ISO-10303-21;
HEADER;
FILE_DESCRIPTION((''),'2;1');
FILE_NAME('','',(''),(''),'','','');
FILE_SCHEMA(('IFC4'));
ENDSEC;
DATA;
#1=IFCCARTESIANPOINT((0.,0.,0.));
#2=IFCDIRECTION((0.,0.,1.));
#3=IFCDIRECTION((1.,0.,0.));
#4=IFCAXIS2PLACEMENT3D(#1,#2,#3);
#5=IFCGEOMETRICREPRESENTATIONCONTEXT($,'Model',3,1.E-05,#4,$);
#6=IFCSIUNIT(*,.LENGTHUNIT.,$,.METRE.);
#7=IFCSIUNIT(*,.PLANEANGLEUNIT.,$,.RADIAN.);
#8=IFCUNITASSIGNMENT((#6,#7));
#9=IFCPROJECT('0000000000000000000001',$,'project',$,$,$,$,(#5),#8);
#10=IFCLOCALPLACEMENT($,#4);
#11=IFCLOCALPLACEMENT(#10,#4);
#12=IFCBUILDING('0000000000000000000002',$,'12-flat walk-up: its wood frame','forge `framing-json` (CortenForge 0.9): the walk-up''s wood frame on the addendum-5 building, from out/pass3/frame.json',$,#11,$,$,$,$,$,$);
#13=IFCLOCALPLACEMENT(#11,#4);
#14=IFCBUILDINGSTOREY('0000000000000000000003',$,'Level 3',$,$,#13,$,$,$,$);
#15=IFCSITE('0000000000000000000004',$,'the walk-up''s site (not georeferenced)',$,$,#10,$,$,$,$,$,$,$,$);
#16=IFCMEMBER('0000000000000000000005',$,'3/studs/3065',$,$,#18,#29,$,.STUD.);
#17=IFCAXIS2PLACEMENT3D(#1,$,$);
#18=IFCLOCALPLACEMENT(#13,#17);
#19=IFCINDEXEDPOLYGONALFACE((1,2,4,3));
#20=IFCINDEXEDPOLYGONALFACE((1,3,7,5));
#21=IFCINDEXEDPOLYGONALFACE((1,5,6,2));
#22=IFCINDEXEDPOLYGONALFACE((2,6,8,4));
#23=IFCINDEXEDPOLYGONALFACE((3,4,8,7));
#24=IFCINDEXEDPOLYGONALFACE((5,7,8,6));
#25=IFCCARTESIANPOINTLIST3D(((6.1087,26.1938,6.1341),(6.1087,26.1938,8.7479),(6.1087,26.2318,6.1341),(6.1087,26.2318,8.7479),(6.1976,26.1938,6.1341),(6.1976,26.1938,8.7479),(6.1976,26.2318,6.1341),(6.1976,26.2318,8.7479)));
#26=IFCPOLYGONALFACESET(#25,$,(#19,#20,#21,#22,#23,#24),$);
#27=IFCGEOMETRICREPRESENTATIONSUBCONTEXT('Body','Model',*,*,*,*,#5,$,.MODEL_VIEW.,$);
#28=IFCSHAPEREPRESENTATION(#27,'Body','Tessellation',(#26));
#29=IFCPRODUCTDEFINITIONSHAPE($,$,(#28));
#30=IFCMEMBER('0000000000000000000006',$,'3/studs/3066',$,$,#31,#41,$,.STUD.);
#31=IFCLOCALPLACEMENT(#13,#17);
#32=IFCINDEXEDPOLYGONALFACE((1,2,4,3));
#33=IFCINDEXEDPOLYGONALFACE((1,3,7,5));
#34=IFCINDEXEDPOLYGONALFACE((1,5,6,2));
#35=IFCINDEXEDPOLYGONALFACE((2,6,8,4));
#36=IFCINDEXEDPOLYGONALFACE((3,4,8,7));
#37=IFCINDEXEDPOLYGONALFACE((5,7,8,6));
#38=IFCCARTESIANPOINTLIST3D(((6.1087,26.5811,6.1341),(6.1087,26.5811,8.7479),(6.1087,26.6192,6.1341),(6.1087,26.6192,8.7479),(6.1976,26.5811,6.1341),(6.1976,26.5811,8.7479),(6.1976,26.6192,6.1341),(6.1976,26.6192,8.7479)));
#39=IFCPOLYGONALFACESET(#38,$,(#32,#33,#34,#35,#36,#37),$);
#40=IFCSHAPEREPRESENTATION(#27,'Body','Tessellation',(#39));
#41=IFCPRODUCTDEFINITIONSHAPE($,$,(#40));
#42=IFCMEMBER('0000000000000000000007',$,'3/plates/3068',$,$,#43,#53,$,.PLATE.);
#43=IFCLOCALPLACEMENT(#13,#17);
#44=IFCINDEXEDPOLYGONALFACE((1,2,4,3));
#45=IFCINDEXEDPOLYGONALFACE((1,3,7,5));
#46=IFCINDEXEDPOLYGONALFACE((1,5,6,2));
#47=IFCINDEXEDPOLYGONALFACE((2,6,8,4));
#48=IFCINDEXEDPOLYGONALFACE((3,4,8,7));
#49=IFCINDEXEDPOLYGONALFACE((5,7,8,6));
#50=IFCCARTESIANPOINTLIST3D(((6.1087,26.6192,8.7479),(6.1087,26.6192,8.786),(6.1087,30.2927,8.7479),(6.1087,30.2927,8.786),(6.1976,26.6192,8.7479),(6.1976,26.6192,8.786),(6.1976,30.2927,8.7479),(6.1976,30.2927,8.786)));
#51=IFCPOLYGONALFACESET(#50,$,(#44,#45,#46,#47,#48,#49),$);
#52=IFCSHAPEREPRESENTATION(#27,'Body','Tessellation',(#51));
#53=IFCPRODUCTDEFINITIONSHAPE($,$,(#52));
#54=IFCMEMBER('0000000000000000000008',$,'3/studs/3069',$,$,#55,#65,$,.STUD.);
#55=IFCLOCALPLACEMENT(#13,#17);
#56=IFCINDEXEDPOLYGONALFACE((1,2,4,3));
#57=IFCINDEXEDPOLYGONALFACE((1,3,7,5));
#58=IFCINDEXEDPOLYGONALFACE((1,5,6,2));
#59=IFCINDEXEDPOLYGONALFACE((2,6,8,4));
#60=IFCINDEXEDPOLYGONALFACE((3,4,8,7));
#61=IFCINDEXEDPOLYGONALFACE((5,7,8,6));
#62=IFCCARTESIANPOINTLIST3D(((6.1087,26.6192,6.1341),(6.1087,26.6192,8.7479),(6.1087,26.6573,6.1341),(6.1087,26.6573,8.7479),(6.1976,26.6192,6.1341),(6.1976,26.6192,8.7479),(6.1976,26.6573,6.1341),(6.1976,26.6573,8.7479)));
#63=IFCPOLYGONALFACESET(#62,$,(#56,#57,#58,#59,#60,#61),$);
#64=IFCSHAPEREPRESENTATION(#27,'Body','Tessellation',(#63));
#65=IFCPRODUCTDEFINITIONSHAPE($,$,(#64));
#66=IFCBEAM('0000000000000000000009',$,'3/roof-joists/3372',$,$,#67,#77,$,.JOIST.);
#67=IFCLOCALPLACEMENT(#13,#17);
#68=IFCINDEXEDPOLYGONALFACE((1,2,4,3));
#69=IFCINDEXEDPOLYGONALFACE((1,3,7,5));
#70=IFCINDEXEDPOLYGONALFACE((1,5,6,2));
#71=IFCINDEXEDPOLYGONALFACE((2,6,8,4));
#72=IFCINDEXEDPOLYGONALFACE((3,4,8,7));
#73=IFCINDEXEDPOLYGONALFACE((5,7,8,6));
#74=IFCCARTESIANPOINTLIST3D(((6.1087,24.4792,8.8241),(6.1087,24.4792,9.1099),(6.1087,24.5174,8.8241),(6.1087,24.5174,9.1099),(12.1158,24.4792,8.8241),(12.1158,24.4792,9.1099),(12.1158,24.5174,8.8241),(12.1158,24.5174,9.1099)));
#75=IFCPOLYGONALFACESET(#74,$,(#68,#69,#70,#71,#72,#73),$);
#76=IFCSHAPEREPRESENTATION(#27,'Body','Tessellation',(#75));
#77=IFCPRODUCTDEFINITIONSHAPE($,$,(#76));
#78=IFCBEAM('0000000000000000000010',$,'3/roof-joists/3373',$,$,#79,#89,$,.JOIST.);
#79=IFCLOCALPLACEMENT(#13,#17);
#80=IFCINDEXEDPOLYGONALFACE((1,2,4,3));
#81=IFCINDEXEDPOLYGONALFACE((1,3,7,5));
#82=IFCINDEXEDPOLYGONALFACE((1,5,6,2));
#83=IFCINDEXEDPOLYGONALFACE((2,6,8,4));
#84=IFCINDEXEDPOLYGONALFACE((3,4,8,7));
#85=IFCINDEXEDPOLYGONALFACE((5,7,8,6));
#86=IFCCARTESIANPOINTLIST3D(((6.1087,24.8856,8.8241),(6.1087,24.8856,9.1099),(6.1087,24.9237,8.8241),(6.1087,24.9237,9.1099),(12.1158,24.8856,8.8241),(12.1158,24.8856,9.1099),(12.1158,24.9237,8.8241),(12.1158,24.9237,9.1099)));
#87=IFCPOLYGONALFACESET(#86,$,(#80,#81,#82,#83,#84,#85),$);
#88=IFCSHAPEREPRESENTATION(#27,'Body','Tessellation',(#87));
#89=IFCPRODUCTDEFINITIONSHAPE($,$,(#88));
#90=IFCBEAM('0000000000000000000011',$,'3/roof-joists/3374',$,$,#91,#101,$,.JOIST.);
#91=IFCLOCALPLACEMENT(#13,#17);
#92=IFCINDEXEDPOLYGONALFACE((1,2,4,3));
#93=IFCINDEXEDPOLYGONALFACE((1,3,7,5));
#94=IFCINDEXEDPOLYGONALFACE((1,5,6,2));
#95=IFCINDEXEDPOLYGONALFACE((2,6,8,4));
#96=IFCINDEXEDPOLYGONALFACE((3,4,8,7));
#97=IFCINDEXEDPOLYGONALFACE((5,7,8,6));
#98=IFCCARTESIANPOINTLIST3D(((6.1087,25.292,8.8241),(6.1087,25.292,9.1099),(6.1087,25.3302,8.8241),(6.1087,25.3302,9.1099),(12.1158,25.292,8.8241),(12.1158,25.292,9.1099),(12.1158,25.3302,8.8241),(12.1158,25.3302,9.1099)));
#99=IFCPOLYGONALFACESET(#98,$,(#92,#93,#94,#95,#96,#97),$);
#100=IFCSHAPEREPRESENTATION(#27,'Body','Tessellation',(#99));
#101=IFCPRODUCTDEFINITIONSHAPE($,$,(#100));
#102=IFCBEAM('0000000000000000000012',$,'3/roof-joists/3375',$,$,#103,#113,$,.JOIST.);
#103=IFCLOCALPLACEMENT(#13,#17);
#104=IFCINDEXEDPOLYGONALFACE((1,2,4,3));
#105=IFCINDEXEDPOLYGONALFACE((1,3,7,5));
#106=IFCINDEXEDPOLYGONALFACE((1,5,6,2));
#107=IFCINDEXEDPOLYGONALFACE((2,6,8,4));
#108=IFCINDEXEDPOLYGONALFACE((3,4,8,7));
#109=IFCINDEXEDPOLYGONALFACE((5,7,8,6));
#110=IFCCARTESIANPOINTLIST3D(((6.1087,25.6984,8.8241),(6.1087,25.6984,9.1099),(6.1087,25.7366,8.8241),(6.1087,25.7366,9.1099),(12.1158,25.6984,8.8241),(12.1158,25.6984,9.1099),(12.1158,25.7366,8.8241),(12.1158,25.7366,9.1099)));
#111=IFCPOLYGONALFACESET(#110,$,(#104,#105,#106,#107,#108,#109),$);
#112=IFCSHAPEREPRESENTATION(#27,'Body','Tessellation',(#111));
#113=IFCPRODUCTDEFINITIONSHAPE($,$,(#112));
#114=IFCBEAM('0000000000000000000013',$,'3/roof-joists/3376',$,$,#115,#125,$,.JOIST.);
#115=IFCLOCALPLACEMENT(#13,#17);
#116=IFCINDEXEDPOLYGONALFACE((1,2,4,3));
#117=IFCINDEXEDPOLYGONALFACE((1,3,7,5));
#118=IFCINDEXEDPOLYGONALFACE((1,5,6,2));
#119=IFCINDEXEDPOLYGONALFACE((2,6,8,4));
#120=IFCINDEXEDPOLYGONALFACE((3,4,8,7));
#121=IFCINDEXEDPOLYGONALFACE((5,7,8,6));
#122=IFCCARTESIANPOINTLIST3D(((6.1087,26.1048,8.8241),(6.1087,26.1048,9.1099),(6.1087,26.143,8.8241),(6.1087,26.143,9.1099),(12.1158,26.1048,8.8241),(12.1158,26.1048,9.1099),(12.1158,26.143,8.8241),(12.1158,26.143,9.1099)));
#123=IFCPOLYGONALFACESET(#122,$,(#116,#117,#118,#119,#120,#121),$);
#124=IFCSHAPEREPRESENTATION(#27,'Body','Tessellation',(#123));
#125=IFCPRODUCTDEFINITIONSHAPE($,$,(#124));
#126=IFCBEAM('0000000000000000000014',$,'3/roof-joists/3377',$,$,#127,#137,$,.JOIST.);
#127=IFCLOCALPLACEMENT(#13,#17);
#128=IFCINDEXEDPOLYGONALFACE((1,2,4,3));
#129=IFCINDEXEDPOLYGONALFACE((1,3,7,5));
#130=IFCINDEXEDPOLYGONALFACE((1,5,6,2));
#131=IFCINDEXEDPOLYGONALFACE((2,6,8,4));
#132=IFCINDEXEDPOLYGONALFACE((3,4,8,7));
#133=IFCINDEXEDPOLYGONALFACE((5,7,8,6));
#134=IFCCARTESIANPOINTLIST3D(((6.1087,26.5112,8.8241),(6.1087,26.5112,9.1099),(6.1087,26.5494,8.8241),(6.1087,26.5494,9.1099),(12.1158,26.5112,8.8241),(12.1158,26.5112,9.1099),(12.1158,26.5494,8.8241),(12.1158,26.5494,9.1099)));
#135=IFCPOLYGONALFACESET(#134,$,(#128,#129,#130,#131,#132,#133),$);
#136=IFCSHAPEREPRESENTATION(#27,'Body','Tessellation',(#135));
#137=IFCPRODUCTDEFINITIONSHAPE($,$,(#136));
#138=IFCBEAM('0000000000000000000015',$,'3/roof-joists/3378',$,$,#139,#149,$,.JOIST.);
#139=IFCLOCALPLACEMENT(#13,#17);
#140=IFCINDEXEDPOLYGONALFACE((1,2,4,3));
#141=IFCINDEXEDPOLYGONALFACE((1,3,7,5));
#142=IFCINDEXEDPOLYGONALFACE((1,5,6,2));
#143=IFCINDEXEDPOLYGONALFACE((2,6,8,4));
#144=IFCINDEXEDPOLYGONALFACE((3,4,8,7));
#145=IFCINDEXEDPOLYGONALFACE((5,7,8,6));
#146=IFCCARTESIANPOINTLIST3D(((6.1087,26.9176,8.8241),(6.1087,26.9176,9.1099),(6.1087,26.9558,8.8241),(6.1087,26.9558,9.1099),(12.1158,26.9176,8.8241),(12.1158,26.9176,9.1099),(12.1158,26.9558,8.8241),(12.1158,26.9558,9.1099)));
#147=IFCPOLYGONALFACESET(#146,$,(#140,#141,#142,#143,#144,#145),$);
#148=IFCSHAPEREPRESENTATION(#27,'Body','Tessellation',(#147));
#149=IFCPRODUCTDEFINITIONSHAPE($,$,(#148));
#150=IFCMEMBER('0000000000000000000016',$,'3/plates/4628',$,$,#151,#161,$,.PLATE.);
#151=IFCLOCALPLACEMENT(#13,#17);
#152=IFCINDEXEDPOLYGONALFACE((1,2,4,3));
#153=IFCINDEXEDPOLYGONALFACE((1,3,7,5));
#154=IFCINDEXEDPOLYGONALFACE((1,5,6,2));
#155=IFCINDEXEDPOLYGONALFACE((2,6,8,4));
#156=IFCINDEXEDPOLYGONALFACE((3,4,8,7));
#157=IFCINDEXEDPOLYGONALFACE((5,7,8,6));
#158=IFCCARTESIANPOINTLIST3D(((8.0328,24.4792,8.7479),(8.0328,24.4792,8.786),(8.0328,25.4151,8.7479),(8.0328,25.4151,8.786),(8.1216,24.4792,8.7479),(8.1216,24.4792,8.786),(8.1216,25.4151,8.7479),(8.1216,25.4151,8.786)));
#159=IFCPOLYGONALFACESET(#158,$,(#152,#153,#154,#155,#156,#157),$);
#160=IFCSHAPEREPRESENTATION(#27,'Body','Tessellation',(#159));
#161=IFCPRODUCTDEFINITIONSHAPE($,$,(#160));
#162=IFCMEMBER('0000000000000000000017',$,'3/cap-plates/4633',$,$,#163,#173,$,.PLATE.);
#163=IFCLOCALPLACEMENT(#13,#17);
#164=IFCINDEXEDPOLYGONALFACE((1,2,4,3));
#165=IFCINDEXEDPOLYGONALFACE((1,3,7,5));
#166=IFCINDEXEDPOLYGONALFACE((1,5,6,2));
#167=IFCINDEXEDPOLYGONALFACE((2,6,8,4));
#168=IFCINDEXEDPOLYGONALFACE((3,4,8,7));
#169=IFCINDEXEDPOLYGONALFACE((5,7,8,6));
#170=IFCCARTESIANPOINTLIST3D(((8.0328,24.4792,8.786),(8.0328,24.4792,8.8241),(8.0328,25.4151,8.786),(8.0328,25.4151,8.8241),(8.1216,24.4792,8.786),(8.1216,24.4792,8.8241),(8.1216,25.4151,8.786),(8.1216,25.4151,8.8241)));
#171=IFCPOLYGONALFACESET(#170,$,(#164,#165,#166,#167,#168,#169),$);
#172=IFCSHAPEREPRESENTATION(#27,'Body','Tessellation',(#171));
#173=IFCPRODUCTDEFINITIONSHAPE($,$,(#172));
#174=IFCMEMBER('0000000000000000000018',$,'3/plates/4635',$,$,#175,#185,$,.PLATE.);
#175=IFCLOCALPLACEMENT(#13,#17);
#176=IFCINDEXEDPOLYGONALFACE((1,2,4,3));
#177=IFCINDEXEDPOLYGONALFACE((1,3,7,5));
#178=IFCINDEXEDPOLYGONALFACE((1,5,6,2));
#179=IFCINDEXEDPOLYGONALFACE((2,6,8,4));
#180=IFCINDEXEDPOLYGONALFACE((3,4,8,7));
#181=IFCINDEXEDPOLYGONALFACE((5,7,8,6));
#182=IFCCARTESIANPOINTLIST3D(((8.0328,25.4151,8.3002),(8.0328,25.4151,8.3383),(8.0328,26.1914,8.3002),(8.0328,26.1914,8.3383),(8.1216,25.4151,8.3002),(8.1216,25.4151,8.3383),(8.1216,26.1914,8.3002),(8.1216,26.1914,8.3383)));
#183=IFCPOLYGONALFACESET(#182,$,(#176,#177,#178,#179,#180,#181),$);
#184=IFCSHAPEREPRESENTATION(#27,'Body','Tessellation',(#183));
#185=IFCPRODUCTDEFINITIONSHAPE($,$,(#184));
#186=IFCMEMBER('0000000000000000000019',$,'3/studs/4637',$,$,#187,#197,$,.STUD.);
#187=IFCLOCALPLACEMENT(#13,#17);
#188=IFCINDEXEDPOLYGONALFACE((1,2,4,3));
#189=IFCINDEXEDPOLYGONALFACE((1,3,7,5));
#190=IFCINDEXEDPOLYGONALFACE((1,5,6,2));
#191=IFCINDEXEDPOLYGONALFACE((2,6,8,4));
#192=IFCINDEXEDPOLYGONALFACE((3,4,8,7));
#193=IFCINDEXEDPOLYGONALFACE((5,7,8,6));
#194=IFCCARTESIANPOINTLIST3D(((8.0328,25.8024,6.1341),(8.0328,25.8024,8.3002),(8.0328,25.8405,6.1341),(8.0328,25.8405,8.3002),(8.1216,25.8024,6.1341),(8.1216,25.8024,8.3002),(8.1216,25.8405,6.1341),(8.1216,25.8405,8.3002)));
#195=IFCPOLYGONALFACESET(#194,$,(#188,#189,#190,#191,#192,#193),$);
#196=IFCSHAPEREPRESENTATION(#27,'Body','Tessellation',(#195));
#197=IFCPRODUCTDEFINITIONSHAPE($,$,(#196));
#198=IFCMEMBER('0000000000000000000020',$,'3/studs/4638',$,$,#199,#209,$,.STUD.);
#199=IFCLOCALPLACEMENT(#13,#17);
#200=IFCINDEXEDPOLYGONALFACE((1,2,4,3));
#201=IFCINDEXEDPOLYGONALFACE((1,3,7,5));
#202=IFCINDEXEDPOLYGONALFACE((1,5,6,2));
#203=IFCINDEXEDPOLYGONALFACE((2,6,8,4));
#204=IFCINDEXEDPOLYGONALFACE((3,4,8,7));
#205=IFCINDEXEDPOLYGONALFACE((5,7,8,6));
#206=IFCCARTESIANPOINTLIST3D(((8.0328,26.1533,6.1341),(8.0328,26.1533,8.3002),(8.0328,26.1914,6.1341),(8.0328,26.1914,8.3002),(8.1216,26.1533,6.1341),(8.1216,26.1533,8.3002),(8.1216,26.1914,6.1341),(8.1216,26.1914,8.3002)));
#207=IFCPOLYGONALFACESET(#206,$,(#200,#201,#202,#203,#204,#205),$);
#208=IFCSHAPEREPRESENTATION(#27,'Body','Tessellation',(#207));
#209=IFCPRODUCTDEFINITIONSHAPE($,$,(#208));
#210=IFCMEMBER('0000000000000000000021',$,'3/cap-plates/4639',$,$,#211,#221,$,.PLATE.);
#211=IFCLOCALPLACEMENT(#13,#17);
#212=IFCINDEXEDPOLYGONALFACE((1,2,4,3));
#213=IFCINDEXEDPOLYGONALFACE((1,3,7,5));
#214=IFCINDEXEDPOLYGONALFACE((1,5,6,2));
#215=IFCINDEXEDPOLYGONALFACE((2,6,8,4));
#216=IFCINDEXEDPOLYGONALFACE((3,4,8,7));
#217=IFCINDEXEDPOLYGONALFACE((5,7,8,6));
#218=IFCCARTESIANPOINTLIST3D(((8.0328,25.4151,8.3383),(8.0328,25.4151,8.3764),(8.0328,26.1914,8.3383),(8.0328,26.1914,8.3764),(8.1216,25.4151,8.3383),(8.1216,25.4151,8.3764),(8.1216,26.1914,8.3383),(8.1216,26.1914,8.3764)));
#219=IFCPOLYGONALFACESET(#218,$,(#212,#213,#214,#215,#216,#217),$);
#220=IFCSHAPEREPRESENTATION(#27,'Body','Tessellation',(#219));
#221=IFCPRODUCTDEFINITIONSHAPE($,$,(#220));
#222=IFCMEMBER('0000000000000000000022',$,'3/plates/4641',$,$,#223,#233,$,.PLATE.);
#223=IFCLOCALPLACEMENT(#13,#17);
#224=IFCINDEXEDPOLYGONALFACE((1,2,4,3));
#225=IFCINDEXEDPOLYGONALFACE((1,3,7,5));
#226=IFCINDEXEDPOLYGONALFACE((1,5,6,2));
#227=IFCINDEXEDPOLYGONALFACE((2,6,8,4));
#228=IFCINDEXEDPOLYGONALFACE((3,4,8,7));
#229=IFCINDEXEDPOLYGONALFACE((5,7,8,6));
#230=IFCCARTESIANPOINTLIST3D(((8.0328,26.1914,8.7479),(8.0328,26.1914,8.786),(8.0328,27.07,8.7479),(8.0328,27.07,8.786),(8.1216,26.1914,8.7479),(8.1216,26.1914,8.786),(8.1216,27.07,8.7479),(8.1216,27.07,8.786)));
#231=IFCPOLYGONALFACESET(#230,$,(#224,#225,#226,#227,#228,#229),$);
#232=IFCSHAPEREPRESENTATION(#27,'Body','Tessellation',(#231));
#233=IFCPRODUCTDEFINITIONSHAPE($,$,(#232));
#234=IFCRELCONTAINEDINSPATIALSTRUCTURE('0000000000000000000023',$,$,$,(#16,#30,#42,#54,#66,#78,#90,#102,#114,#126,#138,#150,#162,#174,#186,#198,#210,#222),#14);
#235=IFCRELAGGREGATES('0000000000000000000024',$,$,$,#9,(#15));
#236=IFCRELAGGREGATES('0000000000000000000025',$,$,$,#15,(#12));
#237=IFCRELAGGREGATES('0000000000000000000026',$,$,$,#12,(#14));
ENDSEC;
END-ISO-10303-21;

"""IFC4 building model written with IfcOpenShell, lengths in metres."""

from ifc_helpers import new_model, si_unit, frame, frame_2d, origin, origin_with_axes, place, context, subcontext, project, spatial, rectangle, extrude, element, save


model = new_model("IFC4")

# Units and contexts
model_context = context("Model", 3, precision=1e-05, world=origin_with_axes())
body_context = subcontext(model_context, "Body", "Model", "MODEL_VIEW")
ifc_project = project(units=[si_unit("LENGTHUNIT", "METRE"), si_unit("PLANEANGLEUNIT", "RADIAN")], contexts=[model_context])

# Site, building, storey
site_placement = place(None, origin_with_axes())
site = spatial("IfcSite", under=ifc_project, at=site_placement, Name="the walk-up's site (not georeferenced)")
building_placement = place(site_placement, origin_with_axes())
building = spatial("IfcBuilding", under=site, at=building_placement, Name="12-flat walk-up: its wood frame", Description="forge `framing-json` (CortenForge 0.9): the walk-up's wood frame on the addendum-5 building, from out/pass3/frame.json")
storey_placement = place(building_placement, origin_with_axes())
storey = spatial("IfcBuildingStorey", under=building, at=storey_placement, Name="Level 3")

# Members
for number, where, z_axis, x_axis, name in (
    (1, (6.1087, 26.1938, 6.1341), (0.0, 0.0, 1.0), (1.0, 0.0, 0.0), "3/studs/3065"),
    (2, (6.1087, 26.5811, 6.1341), (0.0, 0.0, 1.0), (1.0, 0.0, 0.0), "3/studs/3066"),
):
    element("IfcMember", number, at=place(storey_placement, frame(where, z_axis=z_axis, x_axis=x_axis)), inside=storey, Name=name, PredefinedType="STUD", context=body_context, shape_type="SweptSolid", body=[
        extrude(rectangle(XDim=0.0889, YDim=0.0381, at=frame_2d((0.0445, 0.0191))), origin(), (0.0, 0.0, 1.0), 2.6138),
    ])
member_1_placement = place(storey_placement, frame((6.1087, 26.6192, 8.7479), z_axis=(0.0, 0.0, 1.0), x_axis=(1.0, 0.0, 0.0)))
element("IfcMember", 3, at=member_1_placement, inside=storey, Name="3/plates/3068", PredefinedType="PLATE", context=body_context, shape_type="SweptSolid", body=[
    extrude(rectangle(XDim=0.0889, YDim=3.6735, at=frame_2d((0.0445, 1.8367))), origin(), (0.0, 0.0, 1.0), 0.0381),
])
member_2_placement = place(storey_placement, frame((6.1087, 26.6192, 6.1341), z_axis=(0.0, 0.0, 1.0), x_axis=(1.0, 0.0, 0.0)))
element("IfcMember", 4, at=member_2_placement, inside=storey, Name="3/studs/3069", PredefinedType="STUD", context=body_context, shape_type="SweptSolid", body=[
    extrude(rectangle(XDim=0.0889, YDim=0.0381, at=frame_2d((0.0445, 0.0191))), origin(), (0.0, 0.0, 1.0), 2.6138),
])

# Beams
for number, where, z_axis, x_axis, name in (
    (5, (6.1087, 24.4793, 8.8241), (0.0, 0.0, 1.0), (1.0, 0.0, 0.0), "3/roof-joists/3372"),
    (6, (6.1087, 24.8856, 8.8241), (0.0, 0.0, 1.0), (1.0, 0.0, 0.0), "3/roof-joists/3373"),
    (7, (6.1087, 25.292, 8.8241), (0.0, 0.0, 1.0), (1.0, 0.0, 0.0), "3/roof-joists/3374"),
    (8, (6.1087, 25.6985, 8.8241), (0.0, 0.0, 1.0), (1.0, 0.0, 0.0), "3/roof-joists/3375"),
    (9, (6.1087, 26.1048, 8.8241), (0.0, 0.0, 1.0), (1.0, 0.0, 0.0), "3/roof-joists/3376"),
    (10, (6.1087, 26.5113, 8.8241), (0.0, 0.0, 1.0), (1.0, 0.0, 0.0), "3/roof-joists/3377"),
    (11, (6.1087, 26.9176, 8.8241), (0.0, 0.0, 1.0), (1.0, 0.0, 0.0), "3/roof-joists/3378"),
):
    element("IfcBeam", number, at=place(storey_placement, frame(where, z_axis=z_axis, x_axis=x_axis)), inside=storey, Name=name, PredefinedType="JOIST", context=body_context, shape_type="SweptSolid", body=[
        extrude(rectangle(XDim=6.0071, YDim=0.0381, at=frame_2d((3.0036, 0.0191))), origin(), (0.0, 0.0, 1.0), 0.2858),
    ])

# Members
for number, where, z_axis, x_axis, name in (
    (12, (8.0328, 24.4793, 8.7479), (0.0, 0.0, 1.0), (1.0, 0.0, 0.0), "3/plates/4628"),
    (13, (8.0328, 24.4793, 8.786), (0.0, 0.0, 1.0), (1.0, 0.0, 0.0), "3/cap-plates/4633"),
):
    element("IfcMember", number, at=place(storey_placement, frame(where, z_axis=z_axis, x_axis=x_axis)), inside=storey, Name=name, PredefinedType="PLATE", context=body_context, shape_type="SweptSolid", body=[
        extrude(rectangle(XDim=0.0889, YDim=0.9358, at=frame_2d((0.0445, 0.4679))), origin(), (0.0, 0.0, 1.0), 0.0381),
    ])
member_3_placement = place(storey_placement, frame((8.0328, 25.4151, 8.3002), z_axis=(0.0, 0.0, 1.0), x_axis=(1.0, 0.0, 0.0)))
element("IfcMember", 14, at=member_3_placement, inside=storey, Name="3/plates/4635", PredefinedType="PLATE", context=body_context, shape_type="SweptSolid", body=[
    extrude(rectangle(XDim=0.0889, YDim=0.7763, at=frame_2d((0.0445, 0.3881))), origin(), (0.0, 0.0, 1.0), 0.0381),
])
for number, where, z_axis, x_axis, name in (
    (15, (8.0328, 25.8024, 6.1341), (0.0, 0.0, 1.0), (1.0, 0.0, 0.0), "3/studs/4637"),
    (16, (8.0328, 26.1533, 6.1341), (0.0, 0.0, 1.0), (1.0, 0.0, 0.0), "3/studs/4638"),
):
    element("IfcMember", number, at=place(storey_placement, frame(where, z_axis=z_axis, x_axis=x_axis)), inside=storey, Name=name, PredefinedType="STUD", context=body_context, shape_type="SweptSolid", body=[
        extrude(rectangle(XDim=0.0889, YDim=0.0381, at=frame_2d((0.0445, 0.0191))), origin(), (0.0, 0.0, 1.0), 2.1661),
    ])
member_4_placement = place(storey_placement, frame((8.0328, 25.4151, 8.3383), z_axis=(0.0, 0.0, 1.0), x_axis=(1.0, 0.0, 0.0)))
element("IfcMember", 17, at=member_4_placement, inside=storey, Name="3/cap-plates/4639", PredefinedType="PLATE", context=body_context, shape_type="SweptSolid", body=[
    extrude(rectangle(XDim=0.0889, YDim=0.7763, at=frame_2d((0.0445, 0.3881))), origin(), (0.0, 0.0, 1.0), 0.0381),
])
member_5_placement = place(storey_placement, frame((8.0328, 26.1914, 8.7479), z_axis=(0.0, 0.0, 1.0), x_axis=(1.0, 0.0, 0.0)))
element("IfcMember", 18, at=member_5_placement, inside=storey, Name="3/plates/4641", PredefinedType="PLATE", context=body_context, shape_type="SweptSolid", body=[
    extrude(rectangle(XDim=0.0889, YDim=0.8787, at=frame_2d((0.0445, 0.4393))), origin(), (0.0, 0.0, 1.0), 0.0381),
])

save(model, "model.ifc")
